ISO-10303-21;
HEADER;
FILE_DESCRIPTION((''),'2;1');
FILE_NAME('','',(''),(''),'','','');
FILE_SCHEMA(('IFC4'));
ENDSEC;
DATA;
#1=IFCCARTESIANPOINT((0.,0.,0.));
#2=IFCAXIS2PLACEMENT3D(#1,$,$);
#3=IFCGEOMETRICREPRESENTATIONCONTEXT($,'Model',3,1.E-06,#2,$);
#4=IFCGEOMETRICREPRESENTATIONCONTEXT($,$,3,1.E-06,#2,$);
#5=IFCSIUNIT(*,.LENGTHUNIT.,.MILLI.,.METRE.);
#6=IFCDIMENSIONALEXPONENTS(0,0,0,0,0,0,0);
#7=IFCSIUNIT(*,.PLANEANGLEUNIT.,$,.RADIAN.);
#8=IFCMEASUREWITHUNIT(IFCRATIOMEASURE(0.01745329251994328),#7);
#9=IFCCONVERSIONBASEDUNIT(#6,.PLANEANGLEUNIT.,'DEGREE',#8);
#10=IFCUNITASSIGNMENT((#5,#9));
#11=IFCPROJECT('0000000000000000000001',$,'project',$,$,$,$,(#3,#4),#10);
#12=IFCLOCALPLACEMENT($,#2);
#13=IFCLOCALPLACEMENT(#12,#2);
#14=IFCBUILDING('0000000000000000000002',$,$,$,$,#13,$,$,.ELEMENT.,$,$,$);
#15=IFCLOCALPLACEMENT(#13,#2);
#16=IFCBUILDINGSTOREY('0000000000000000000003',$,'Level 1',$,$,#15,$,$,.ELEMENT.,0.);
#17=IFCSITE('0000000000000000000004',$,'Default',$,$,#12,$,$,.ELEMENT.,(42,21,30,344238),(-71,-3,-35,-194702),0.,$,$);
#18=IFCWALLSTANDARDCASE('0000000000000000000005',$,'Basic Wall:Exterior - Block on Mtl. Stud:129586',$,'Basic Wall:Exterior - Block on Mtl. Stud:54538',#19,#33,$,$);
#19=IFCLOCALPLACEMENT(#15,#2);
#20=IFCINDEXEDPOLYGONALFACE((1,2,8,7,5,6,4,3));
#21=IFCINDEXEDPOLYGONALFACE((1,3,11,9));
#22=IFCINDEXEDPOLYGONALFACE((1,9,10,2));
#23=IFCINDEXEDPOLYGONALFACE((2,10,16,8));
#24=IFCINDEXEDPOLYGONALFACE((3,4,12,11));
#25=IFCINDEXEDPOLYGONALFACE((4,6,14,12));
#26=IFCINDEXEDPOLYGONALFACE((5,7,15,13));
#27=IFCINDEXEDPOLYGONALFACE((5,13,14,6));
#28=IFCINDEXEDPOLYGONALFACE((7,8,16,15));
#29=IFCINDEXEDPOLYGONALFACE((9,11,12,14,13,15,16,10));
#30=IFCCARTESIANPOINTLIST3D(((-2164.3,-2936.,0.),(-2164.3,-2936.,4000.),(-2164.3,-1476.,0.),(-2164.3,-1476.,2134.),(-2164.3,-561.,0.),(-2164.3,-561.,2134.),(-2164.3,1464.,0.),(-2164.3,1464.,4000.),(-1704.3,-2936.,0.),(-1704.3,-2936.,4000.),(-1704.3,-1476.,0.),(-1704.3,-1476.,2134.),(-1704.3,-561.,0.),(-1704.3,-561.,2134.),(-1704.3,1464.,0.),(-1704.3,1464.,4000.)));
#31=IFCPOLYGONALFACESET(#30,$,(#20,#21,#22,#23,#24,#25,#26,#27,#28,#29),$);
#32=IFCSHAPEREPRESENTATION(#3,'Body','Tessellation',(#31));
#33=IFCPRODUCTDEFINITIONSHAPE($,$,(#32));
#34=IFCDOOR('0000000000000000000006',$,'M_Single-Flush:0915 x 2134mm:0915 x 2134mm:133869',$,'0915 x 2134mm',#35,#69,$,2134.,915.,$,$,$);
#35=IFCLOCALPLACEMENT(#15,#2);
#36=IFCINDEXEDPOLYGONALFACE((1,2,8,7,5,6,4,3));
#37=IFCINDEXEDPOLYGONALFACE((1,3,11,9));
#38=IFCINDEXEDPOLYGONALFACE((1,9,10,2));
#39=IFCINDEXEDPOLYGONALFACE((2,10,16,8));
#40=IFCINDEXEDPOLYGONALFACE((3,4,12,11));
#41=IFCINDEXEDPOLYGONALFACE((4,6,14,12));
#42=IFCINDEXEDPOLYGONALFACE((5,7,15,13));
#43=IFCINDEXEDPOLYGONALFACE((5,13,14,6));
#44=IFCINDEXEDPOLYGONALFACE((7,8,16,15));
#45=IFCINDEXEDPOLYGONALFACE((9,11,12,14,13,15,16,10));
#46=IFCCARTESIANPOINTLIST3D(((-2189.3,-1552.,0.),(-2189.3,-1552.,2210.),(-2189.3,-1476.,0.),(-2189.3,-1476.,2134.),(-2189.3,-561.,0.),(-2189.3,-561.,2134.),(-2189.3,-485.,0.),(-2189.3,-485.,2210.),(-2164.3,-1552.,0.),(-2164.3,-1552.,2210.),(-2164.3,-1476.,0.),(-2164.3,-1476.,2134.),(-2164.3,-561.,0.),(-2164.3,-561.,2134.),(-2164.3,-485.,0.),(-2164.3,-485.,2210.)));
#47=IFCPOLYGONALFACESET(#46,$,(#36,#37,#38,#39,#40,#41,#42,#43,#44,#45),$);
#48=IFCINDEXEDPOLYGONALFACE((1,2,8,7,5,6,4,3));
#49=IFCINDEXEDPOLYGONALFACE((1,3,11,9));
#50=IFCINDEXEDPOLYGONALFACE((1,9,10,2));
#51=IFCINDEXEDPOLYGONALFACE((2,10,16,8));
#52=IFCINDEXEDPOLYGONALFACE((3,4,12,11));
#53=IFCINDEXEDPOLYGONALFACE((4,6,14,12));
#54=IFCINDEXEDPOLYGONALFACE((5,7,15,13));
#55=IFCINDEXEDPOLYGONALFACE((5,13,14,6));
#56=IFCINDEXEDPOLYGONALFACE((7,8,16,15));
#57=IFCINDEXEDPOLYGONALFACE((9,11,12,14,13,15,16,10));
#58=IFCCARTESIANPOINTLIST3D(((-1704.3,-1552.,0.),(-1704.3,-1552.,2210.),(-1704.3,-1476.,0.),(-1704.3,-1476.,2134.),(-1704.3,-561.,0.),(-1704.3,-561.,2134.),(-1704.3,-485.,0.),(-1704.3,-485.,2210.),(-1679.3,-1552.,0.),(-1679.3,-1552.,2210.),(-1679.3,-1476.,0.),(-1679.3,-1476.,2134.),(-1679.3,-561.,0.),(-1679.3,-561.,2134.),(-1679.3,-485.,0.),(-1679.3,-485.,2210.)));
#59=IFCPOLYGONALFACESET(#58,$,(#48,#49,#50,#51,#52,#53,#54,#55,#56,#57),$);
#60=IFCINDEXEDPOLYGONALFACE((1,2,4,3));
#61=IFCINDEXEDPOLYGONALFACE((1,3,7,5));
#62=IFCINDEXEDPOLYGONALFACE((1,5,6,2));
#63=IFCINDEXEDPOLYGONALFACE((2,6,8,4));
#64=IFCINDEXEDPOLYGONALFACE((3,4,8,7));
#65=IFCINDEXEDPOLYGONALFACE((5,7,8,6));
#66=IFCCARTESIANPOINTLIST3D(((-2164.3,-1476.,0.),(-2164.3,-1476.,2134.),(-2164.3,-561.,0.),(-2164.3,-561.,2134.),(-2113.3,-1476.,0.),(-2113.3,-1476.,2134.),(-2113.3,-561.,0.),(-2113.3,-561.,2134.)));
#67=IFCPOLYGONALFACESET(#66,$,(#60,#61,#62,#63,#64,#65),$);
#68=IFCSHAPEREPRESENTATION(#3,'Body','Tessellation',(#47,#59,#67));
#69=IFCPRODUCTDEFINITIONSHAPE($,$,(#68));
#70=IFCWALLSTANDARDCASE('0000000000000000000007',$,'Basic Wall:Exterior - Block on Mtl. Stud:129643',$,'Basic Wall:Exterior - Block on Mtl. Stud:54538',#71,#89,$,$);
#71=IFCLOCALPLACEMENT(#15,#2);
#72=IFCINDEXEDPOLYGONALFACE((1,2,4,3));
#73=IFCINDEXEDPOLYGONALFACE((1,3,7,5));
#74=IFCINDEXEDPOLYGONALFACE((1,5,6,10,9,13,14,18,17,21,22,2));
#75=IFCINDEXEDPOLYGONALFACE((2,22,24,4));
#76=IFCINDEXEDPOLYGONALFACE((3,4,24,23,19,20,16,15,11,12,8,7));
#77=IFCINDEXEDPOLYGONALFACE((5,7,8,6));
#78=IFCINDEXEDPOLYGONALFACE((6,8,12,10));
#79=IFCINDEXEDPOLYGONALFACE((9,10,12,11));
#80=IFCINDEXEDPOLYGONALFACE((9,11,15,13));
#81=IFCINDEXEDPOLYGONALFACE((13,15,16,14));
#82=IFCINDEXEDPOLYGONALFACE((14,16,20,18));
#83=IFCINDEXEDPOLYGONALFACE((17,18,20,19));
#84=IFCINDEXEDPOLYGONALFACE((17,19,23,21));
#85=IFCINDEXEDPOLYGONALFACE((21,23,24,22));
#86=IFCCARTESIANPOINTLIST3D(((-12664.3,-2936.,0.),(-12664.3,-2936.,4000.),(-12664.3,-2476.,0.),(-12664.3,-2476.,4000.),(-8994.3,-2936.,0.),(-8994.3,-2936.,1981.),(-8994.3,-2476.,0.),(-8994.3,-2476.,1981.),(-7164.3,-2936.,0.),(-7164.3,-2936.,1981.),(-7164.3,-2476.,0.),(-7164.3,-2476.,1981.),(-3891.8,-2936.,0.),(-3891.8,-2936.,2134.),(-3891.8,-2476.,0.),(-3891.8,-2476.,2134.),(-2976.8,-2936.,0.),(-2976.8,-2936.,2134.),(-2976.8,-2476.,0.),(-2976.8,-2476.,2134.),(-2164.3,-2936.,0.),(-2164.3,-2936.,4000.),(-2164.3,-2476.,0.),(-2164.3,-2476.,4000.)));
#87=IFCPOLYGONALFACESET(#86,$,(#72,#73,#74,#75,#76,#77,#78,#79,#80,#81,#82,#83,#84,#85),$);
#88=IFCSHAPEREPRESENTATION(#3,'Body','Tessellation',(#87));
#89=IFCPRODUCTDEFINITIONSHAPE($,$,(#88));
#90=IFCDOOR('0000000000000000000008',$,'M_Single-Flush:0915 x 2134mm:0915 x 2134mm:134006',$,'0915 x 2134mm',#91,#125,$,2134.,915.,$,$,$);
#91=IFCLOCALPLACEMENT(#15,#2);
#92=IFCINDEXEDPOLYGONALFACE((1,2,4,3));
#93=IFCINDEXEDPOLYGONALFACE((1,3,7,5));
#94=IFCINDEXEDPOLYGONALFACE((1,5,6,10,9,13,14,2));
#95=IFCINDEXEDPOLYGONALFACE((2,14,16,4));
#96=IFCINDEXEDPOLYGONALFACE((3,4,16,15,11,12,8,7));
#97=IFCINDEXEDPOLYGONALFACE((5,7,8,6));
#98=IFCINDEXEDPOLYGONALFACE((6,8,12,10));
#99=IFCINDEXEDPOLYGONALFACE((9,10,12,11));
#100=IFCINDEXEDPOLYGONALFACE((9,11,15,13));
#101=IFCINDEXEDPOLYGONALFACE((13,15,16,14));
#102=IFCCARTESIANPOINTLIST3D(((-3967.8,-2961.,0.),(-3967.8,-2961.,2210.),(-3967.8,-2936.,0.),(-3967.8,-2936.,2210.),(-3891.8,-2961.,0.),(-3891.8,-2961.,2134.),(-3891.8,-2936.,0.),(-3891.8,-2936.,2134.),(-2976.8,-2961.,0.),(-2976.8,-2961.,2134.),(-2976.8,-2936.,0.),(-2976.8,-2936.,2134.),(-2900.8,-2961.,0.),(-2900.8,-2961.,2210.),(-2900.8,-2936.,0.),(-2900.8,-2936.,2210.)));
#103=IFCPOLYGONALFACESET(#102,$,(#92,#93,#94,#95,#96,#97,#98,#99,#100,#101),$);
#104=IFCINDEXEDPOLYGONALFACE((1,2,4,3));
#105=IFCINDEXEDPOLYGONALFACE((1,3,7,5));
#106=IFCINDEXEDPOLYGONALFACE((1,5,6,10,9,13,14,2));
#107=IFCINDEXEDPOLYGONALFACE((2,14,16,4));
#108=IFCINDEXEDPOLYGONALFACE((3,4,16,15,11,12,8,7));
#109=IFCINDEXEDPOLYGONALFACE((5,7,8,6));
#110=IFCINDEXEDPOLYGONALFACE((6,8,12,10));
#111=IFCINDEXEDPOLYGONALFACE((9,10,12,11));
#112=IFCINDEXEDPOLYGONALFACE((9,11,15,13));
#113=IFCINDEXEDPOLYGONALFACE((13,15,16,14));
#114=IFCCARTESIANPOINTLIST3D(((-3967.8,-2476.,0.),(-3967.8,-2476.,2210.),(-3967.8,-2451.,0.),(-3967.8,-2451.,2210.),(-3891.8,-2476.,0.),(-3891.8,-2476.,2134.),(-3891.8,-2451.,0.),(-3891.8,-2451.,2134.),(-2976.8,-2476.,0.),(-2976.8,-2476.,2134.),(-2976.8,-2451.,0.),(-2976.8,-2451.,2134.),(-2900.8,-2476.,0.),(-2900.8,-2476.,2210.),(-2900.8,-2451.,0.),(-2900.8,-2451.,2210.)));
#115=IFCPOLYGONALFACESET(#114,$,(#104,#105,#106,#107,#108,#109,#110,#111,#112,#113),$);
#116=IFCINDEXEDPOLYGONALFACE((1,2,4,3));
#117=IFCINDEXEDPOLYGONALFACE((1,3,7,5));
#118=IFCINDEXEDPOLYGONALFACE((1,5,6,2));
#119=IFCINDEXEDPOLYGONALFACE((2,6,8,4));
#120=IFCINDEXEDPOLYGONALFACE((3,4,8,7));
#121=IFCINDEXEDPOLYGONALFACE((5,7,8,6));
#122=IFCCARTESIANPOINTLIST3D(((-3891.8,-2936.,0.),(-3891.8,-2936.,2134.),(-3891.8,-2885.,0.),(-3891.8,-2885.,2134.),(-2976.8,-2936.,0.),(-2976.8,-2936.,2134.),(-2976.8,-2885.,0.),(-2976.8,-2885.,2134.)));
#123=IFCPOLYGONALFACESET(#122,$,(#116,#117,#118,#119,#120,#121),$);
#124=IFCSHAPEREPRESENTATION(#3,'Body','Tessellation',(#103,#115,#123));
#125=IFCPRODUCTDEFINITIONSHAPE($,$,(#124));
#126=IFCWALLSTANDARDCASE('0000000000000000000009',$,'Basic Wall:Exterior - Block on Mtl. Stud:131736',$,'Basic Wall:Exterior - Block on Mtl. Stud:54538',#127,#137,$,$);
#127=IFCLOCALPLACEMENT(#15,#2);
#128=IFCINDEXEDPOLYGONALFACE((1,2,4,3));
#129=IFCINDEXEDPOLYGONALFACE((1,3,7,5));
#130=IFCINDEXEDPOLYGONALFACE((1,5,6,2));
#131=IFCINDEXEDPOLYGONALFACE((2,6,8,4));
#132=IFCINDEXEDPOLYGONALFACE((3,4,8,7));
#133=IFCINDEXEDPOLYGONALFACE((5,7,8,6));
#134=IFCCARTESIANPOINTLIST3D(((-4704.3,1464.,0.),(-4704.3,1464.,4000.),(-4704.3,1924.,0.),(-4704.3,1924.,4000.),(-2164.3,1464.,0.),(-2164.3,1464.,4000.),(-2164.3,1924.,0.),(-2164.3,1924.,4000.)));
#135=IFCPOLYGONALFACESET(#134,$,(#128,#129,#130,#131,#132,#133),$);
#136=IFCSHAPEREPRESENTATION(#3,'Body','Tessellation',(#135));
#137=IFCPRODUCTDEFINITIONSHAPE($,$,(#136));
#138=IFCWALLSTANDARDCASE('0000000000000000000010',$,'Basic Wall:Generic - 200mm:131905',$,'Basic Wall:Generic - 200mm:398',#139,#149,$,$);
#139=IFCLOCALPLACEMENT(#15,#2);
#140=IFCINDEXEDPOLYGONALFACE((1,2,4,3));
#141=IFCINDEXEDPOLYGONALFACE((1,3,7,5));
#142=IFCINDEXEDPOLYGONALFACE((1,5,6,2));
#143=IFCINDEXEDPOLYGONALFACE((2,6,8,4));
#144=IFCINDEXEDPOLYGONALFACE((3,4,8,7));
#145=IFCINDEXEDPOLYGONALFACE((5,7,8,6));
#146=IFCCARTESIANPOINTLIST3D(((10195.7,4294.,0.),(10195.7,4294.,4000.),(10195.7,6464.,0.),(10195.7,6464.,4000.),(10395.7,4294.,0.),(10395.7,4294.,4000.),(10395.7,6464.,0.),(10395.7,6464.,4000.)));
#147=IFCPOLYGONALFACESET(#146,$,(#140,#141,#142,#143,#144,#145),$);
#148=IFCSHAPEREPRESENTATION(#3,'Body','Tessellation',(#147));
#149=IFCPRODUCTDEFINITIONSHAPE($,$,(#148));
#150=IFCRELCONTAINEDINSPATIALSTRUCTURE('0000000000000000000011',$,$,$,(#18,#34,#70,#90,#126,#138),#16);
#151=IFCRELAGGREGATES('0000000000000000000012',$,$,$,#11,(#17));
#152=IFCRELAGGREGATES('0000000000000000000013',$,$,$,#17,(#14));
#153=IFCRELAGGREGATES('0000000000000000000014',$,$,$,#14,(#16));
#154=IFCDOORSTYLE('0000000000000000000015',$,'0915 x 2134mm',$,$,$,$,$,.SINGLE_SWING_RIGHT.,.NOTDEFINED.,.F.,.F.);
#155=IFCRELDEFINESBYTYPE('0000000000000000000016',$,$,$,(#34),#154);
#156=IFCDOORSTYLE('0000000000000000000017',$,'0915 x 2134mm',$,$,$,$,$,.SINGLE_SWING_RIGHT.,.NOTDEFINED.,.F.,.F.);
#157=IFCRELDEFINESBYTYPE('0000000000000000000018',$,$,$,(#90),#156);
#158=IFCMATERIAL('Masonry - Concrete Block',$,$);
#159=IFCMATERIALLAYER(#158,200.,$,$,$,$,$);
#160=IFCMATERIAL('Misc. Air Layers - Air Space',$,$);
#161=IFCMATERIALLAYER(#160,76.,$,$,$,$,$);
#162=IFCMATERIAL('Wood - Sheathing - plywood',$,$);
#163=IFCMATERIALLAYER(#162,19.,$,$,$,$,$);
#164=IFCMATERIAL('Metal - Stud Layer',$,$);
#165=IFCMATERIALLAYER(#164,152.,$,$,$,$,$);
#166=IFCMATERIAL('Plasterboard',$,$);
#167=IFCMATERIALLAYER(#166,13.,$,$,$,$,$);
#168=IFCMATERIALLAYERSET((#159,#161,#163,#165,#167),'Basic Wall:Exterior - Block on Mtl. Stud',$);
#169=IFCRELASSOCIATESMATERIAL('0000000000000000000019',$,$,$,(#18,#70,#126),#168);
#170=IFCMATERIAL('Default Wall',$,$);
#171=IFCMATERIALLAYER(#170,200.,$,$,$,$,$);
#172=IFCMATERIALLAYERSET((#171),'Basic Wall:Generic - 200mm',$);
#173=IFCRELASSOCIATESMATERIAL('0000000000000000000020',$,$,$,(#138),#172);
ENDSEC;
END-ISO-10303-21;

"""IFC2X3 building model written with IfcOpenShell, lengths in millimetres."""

from ifc_helpers import new_model, entity, si_unit, converted_unit, frame, frame_2d, origin, origin_2d_with_axis, place, context, project, spatial, polyline, rectangle, outline, extrude, source, transform, mapped, material, layer, layer_set, layer_usage, type_object, type_shapes, element, fill, save


model = new_model("IFC2X3")

# Units and contexts
model_context = context("Model", 3, precision=1e-06, world=origin())
context_of_model = context(None, 3, precision=1e-06, world=origin())
ifc_project = project(units=[si_unit("LENGTHUNIT", "METRE", prefix="MILLI"), converted_unit("PLANEANGLEUNIT", "DEGREE", entity("IfcRatioMeasure", 0.01745329251994328), si_unit("PLANEANGLEUNIT", "RADIAN"), dimensions=[0, 0, 0, 0, 0, 0, 0])], contexts=[model_context, context_of_model])

# Site, building, storey
site_placement = place(None, origin())
site = spatial("IfcSite", under=ifc_project, at=site_placement, Name="Default", CompositionType="ELEMENT", RefLatitude=(42, 21, 30, 344238), RefLongitude=(-71, -3, -35, -194702), RefElevation=0.0)
building_placement = place(site_placement, origin())
building = spatial("IfcBuilding", under=site, at=building_placement, CompositionType="ELEMENT")
storey_placement = place(building_placement, origin())
storey = spatial("IfcBuildingStorey", under=building, at=storey_placement, Name="Level 1", CompositionType="ELEMENT", Elevation=0.0)

# Shared definitions
ifc_material_1 = material(Name="Masonry - Concrete Block")
ifc_layer_1 = layer(ifc_material_1, 200.0)
ifc_material_2 = material(Name="Misc. Air Layers - Air Space")
ifc_layer_2 = layer(ifc_material_2, 76.0)
ifc_material_3 = material(Name="Wood - Sheathing - plywood")
ifc_layer_3 = layer(ifc_material_3, 19.0)
ifc_material_4 = material(Name="Metal - Stud Layer")
ifc_layer_4 = layer(ifc_material_4, 152.0)
ifc_material_5 = material(Name="Plasterboard")
ifc_layer_5 = layer(ifc_material_5, 13.0)
ifc_layer_set_1 = layer_set([ifc_layer_1, ifc_layer_2, ifc_layer_3, ifc_layer_4, ifc_layer_5], Name="Basic Wall:Exterior - Block on Mtl. Stud")

# Wall, opening, door
door_style_1 = type_object("IfcDoorStyle", Name="0915 x 2134mm", ConstructionType="NOTDEFINED", OperationType="SINGLE_SWING_RIGHT", ParameterTakesPrecedence=False, Sizeable=False)
shared_shape_1 = source(origin(), model_context, "Body", "SweptSolid", [
    extrude(outline(polyline([(-533.5, -1124.0), (533.5, -1124.0), (533.5, 1086.0), (457.5, 1086.0), (457.5, -1048.0), (-457.5, -1048.0), (-457.5, 1086.0), (-533.5, 1086.0), (-533.5, -1124.0)])), frame((457.5, 460.0, 1086.0), z_axis=(0.0, 1.0, 0.0), x_axis=(1.0, 0.0, 0.0)), (0.0, 0.0, 1.0), 25.0),
    extrude(outline(polyline([(-1124.0, -533.5), (1086.0, -533.5), (1086.0, -457.5), (-1048.0, -457.5), (-1048.0, 457.5), (1086.0, 457.5), (1086.0, 533.5), (-1124.0, 533.5), (-1124.0, -533.5)])), frame((457.5, -25.0, 1086.0), z_axis=(0.0, 1.0, 0.0), x_axis=(0.0, 0.0, -1.0)), (0.0, 0.0, 1.0), 25.0),
    extrude(rectangle(XDim=51.0, YDim=915.0, at=origin_2d_with_axis()), frame((457.5, 434.5, 0.0), z_axis=(0.0, 0.0, 1.0), x_axis=(0.0, 1.0, 0.0)), (0.0, 0.0, 1.0), 2134.0),
])
type_shapes(door_style_1, [shared_shape_1])
ifc_layer_usage_1 = layer_usage(ifc_layer_set_1, "AXIS2", "NEGATIVE", 230.0)
wall_1_placement = place(storey_placement, frame((-1934.3, 1464.0, 0.0), z_axis=(0.0, 0.0, 1.0), x_axis=(0.0, -1.0, 0.0)))
wall_1 = element("IfcWallStandardCase", 1, at=wall_1_placement, inside=storey, material=ifc_layer_usage_1, Name="Basic Wall:Exterior - Block on Mtl. Stud:129586", ObjectType="Basic Wall:Exterior - Block on Mtl. Stud:54538", context=model_context, shape_type="SweptSolid", body=[
    extrude(rectangle(XDim=4400.0, YDim=460.0, at=frame_2d((2200.0, 0.0), x_axis=(-1.0, 0.0))), origin(), (0.0, 0.0, 1.0), 4000.0),
])
opening_1_placement = place(wall_1_placement, frame((2940.0, 230.0, 0.0)))
opening_1 = element("IfcOpeningElement", 2, at=opening_1_placement, cuts=wall_1, ObjectType="Opening", context=model_context, shape_type="SweptSolid", body=[
    extrude(rectangle(XDim=915.0, YDim=2134.0, at=frame_2d((1067.0, 457.5), x_axis=(0.0, 1.0))), frame((0.0, 0.0, 0.0), z_axis=(0.0, -1.0, 0.0), x_axis=(0.0, 0.0, 1.0)), (0.0, 0.0, 1.0), 460.0),
])
door_1_placement = place(opening_1_placement, frame((0.0, 0.0, 0.0), z_axis=(0.0, 0.0, 1.0), x_axis=(-1.0, 0.0, 0.0)))
door_1 = element("IfcDoor", 3, at=door_1_placement, inside=storey, type_object=door_style_1, Name="M_Single-Flush:0915 x 2134mm:0915 x 2134mm:133869", ObjectType="0915 x 2134mm", OverallHeight=2134.0, OverallWidth=915.0, context=model_context, shape_type="MappedRepresentation", body=[
    mapped(shared_shape_1, transform((0.0, 0.0, 0.0), scale=1.0)),
])
fill(opening_1, door_1)

# Wall, openings, door
ifc_layer_usage_2 = layer_usage(ifc_layer_set_1, "AXIS2", "NEGATIVE", 230.0)
wall_2_placement = place(storey_placement, frame((-2164.3, -2706.0, 0.0), z_axis=(0.0, 0.0, 1.0), x_axis=(-1.0, 0.0, 0.0)))
wall_2 = element("IfcWallStandardCase", 4, at=wall_2_placement, inside=storey, material=ifc_layer_usage_2, Name="Basic Wall:Exterior - Block on Mtl. Stud:129643", ObjectType="Basic Wall:Exterior - Block on Mtl. Stud:54538", context=model_context, shape_type="SweptSolid", body=[
    extrude(rectangle(XDim=10500.0, YDim=460.0, at=frame_2d((5250.0, 0.0), x_axis=(-1.0, 0.0))), origin(), (0.0, 0.0, 1.0), 4000.0),
])
opening_2_placement = place(wall_2_placement, frame((812.5, -230.0, 0.0)))
opening_2 = element("IfcOpeningElement", 5, at=opening_2_placement, cuts=wall_2, ObjectType="Opening", context=model_context, shape_type="SweptSolid", body=[
    extrude(rectangle(XDim=915.0, YDim=2134.0, at=frame_2d((1067.0, 457.5), x_axis=(0.0, 1.0))), frame((0.0, 0.0, 0.0), z_axis=(0.0, 1.0, 0.0), x_axis=(0.0, 0.0, 1.0)), (0.0, 0.0, 1.0), 460.0),
])
opening_3_placement = place(wall_2_placement, frame((5000.0, -230.0, 0.0)))
element("IfcOpeningElement", 6, at=opening_3_placement, cuts=wall_2, ObjectType="Opening", context=model_context, shape_type="SweptSolid", body=[
    extrude(rectangle(XDim=1981.0, YDim=1830.0, at=frame_2d((990.5, 915.0), x_axis=(1.0, 0.0))), frame((0.0, 0.0, 0.0), z_axis=(0.0, 1.0, 0.0), x_axis=(0.0, 0.0, 1.0)), (0.0, 0.0, 1.0), 460.0),
])
door_style_2 = type_object("IfcDoorStyle", Name="0915 x 2134mm", ConstructionType="NOTDEFINED", OperationType="SINGLE_SWING_RIGHT", ParameterTakesPrecedence=False, Sizeable=False)
shared_shape_2 = source(origin(), model_context, "Body", "SweptSolid", [
    extrude(outline(polyline([(-533.5, -1124.0), (533.5, -1124.0), (533.5, 1086.0), (457.5, 1086.0), (457.5, -1048.0), (-457.5, -1048.0), (-457.5, 1086.0), (-533.5, 1086.0), (-533.5, -1124.0)])), frame((457.5, 460.0, 1086.0), z_axis=(0.0, 1.0, 0.0), x_axis=(1.0, 0.0, 0.0)), (0.0, 0.0, 1.0), 25.0),
    extrude(outline(polyline([(-1124.0, -533.5), (1086.0, -533.5), (1086.0, -457.5), (-1048.0, -457.5), (-1048.0, 457.5), (1086.0, 457.5), (1086.0, 533.5), (-1124.0, 533.5), (-1124.0, -533.5)])), frame((457.5, -25.0, 1086.0), z_axis=(0.0, 1.0, 0.0), x_axis=(0.0, 0.0, -1.0)), (0.0, 0.0, 1.0), 25.0),
    extrude(rectangle(XDim=51.0, YDim=915.0, at=origin_2d_with_axis()), frame((457.5, 434.5, 0.0), z_axis=(0.0, 0.0, 1.0), x_axis=(0.0, 1.0, 0.0)), (0.0, 0.0, 1.0), 2134.0),
])
type_shapes(door_style_2, [shared_shape_2])
door_2_placement = place(opening_2_placement, origin())
door_2 = element("IfcDoor", 7, at=door_2_placement, inside=storey, type_object=door_style_2, Name="M_Single-Flush:0915 x 2134mm:0915 x 2134mm:134006", ObjectType="0915 x 2134mm", OverallHeight=2134.0, OverallWidth=915.0, context=model_context, shape_type="MappedRepresentation", body=[
    mapped(shared_shape_2, transform((0.0, 0.0, 0.0), scale=1.0)),
])
fill(opening_2, door_2)

# Walls
ifc_layer_usage_3 = layer_usage(ifc_layer_set_1, "AXIS2", "NEGATIVE", 230.0)
wall_3_placement = place(storey_placement, frame((-2164.3, 1694.0, 0.0), z_axis=(0.0, 0.0, 1.0), x_axis=(-1.0, 0.0, 0.0)))
element("IfcWallStandardCase", 8, at=wall_3_placement, inside=storey, material=ifc_layer_usage_3, Name="Basic Wall:Exterior - Block on Mtl. Stud:131736", ObjectType="Basic Wall:Exterior - Block on Mtl. Stud:54538", context=model_context, shape_type="SweptSolid", body=[
    extrude(rectangle(XDim=2540.0, YDim=460.0, at=frame_2d((1270.0, 0.0), x_axis=(-1.0, 0.0))), origin(), (0.0, 0.0, 1.0), 4000.0),
])
ifc_material_6 = material(Name="Default Wall")
ifc_layer_6 = layer(ifc_material_6, 200.0)
ifc_layer_set_2 = layer_set([ifc_layer_6], Name="Basic Wall:Generic - 200mm")
ifc_layer_usage_4 = layer_usage(ifc_layer_set_2, "AXIS2", "NEGATIVE", 100.0)
wall_4_placement = place(storey_placement, frame((10295.7, 6464.0, 0.0), z_axis=(0.0, 0.0, 1.0), x_axis=(0.0, -1.0, 0.0)))
element("IfcWallStandardCase", 9, at=wall_4_placement, inside=storey, material=ifc_layer_usage_4, Name="Basic Wall:Generic - 200mm:131905", ObjectType="Basic Wall:Generic - 200mm:398", context=model_context, shape_type="SweptSolid", body=[
    extrude(rectangle(XDim=2170.0, YDim=200.0, at=frame_2d((1085.0, 0.0), x_axis=(-1.0, 0.0))), origin(), (0.0, 0.0, 1.0), 4000.0),
])

save(model, "model.ifc")
